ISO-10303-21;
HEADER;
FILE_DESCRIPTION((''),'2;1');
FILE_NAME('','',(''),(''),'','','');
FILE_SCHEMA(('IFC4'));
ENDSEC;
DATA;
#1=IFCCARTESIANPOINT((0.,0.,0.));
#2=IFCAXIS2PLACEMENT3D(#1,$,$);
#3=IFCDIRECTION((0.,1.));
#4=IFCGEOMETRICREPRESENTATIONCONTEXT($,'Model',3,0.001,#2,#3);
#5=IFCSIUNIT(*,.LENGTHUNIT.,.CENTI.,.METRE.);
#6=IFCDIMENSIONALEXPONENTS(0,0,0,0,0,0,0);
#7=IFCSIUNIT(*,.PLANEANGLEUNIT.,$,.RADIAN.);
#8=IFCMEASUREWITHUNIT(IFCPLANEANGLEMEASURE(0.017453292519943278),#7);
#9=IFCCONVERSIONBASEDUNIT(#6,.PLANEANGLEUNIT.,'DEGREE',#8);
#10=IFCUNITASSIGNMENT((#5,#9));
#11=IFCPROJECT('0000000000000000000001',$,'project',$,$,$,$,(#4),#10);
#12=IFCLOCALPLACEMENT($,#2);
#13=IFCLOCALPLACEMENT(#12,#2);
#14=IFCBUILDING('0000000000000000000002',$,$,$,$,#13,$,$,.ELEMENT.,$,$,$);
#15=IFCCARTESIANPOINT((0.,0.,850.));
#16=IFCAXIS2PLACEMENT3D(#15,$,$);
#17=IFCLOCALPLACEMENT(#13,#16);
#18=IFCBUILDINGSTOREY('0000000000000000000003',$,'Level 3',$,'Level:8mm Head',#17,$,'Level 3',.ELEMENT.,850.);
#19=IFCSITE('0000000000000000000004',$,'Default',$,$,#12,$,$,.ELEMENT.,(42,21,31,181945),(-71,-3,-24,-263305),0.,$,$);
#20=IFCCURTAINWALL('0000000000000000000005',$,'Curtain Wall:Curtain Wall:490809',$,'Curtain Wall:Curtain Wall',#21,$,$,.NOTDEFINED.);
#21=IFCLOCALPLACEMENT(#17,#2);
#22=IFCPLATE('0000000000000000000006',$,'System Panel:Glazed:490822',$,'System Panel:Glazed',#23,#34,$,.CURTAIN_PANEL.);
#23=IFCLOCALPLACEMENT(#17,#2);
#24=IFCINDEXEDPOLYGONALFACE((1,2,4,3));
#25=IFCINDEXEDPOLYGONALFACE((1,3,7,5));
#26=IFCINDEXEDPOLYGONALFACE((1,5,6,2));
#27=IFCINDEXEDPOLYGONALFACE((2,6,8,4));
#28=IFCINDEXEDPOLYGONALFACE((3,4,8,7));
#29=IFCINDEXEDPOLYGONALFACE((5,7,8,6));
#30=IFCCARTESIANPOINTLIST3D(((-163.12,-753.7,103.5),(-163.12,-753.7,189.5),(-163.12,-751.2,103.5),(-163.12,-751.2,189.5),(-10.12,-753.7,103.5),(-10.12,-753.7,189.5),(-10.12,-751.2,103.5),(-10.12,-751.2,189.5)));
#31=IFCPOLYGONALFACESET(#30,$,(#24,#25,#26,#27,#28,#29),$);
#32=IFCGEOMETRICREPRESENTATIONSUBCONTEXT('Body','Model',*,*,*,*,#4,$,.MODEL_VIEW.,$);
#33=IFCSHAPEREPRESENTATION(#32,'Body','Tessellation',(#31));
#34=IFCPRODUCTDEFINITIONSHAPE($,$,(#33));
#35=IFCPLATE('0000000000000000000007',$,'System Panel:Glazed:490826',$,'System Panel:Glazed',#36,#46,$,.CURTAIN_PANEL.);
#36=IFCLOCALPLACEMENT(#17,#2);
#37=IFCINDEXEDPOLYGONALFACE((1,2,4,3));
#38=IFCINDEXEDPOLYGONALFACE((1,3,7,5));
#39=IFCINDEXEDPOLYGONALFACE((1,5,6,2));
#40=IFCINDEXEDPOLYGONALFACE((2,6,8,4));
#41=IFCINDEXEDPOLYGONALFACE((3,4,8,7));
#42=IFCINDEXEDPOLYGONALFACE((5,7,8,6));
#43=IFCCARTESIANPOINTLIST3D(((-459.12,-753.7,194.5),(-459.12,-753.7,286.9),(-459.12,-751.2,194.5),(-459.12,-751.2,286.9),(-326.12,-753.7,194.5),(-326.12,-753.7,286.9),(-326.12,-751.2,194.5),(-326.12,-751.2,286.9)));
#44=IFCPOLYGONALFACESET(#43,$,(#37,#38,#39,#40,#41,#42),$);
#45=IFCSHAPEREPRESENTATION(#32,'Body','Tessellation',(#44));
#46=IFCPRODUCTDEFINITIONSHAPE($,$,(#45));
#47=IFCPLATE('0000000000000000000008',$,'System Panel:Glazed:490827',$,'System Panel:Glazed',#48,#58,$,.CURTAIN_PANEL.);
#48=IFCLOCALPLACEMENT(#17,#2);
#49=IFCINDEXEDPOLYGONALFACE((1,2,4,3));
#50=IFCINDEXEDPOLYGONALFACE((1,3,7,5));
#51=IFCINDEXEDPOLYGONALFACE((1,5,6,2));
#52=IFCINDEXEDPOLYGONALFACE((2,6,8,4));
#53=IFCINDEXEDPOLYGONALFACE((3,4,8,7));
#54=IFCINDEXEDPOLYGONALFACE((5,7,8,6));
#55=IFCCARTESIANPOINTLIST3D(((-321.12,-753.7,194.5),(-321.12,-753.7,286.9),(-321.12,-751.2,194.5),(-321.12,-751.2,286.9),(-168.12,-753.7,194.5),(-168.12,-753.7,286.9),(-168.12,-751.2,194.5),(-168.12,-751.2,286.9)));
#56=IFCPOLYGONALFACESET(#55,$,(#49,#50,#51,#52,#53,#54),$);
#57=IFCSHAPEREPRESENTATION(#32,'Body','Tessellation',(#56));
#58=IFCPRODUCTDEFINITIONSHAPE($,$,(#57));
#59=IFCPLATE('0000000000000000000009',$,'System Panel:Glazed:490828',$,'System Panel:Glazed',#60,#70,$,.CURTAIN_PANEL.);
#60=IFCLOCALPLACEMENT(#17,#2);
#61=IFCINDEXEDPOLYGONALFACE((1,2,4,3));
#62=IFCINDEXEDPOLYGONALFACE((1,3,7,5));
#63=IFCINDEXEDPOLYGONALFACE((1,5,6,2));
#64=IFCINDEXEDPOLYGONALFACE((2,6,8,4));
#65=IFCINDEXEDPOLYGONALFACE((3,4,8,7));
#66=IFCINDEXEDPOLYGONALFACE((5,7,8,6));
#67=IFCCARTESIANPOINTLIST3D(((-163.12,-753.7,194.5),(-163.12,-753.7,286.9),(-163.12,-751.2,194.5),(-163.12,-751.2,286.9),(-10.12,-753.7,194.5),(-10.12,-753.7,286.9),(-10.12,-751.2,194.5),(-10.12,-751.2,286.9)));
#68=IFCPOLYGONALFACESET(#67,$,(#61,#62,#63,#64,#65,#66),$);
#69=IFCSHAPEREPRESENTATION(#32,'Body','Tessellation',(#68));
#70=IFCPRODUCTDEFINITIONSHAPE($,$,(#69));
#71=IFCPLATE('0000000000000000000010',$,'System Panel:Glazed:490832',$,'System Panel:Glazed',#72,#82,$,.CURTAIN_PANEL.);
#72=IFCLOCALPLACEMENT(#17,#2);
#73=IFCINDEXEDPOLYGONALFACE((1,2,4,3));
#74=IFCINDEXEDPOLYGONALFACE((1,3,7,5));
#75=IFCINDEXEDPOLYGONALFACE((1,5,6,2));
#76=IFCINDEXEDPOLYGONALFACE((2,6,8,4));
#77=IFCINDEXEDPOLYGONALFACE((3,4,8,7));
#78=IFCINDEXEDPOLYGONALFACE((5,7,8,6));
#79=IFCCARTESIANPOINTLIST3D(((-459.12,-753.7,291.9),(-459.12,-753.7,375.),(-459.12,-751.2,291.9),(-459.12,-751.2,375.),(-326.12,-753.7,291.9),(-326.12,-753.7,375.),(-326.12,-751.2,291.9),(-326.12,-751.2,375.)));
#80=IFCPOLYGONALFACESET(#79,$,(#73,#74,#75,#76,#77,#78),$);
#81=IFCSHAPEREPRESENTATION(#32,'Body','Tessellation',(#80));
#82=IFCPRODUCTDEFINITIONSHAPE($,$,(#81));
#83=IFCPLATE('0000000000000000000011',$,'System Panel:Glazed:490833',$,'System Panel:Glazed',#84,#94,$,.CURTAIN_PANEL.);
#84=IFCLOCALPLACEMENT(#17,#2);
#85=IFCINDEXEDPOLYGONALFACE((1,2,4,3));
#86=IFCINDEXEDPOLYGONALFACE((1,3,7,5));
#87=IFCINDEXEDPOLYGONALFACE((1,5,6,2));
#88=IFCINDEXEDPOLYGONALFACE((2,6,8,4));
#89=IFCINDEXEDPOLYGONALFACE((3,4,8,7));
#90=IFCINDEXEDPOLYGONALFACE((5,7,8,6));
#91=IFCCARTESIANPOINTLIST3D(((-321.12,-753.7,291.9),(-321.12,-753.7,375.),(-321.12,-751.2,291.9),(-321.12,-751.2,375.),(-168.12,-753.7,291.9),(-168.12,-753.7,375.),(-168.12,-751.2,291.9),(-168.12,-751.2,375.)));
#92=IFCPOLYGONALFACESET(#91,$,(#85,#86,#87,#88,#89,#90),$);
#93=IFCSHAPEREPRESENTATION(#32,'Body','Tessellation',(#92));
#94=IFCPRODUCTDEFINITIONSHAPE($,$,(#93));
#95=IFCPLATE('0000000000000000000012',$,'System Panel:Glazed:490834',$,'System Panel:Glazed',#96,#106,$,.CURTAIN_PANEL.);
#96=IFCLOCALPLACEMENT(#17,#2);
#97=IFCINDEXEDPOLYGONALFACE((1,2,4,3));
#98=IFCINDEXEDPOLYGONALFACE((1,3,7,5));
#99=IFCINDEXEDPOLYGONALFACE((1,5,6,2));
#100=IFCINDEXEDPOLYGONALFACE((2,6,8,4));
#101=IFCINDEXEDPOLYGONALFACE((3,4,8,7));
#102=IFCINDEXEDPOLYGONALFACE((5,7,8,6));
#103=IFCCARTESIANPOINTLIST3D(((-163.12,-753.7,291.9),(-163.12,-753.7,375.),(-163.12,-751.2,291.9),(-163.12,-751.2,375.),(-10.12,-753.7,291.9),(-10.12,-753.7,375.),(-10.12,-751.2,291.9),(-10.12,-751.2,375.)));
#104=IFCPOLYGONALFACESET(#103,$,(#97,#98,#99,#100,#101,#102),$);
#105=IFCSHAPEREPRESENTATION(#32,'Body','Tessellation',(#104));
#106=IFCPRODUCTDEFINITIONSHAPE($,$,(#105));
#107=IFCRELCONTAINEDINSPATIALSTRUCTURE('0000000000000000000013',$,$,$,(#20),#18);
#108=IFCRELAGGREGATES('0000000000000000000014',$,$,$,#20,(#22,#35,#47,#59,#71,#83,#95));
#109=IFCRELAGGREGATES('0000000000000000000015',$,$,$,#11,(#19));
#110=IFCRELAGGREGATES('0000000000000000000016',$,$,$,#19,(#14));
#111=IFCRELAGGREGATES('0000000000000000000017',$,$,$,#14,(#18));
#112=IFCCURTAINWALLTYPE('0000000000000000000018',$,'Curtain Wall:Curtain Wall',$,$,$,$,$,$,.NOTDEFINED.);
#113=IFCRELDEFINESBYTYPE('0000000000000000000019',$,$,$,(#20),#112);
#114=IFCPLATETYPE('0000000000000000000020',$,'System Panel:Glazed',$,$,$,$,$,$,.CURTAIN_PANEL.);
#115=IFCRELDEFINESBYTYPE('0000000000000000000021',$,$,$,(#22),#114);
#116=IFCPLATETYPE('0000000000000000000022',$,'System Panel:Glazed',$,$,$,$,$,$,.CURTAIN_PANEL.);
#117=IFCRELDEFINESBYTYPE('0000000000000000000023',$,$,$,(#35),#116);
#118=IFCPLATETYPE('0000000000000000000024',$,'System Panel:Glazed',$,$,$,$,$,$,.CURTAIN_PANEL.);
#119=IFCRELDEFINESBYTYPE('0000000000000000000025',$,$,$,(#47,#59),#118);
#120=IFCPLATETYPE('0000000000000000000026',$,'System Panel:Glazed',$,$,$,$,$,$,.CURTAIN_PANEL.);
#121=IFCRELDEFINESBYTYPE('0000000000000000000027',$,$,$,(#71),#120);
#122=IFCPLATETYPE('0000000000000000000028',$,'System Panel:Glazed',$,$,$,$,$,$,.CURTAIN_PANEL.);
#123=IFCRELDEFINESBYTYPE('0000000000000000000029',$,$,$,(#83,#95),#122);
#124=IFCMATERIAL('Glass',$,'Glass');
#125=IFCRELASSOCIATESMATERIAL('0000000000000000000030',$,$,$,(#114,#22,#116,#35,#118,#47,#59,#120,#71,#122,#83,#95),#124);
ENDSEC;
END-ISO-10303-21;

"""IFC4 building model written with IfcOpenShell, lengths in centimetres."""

from ifc_helpers import new_model, entity, si_unit, converted_unit, direction, frame, origin, place, context, subcontext, project, spatial, indexed_curve, outline, extrude, source, transform, mapped, material, type_object, type_shapes, element, aggregate, save


model = new_model("IFC4")

# Units and contexts
model_context = context("Model", 3, precision=0.001, world=origin(), true_north=direction((0.0, 1.0)))
body_context = subcontext(model_context, "Body", "Model", "MODEL_VIEW")
ifc_project = project(units=[si_unit("LENGTHUNIT", "METRE", prefix="CENTI"), converted_unit("PLANEANGLEUNIT", "DEGREE", entity("IfcPlaneAngleMeasure", 0.017453292519943278), si_unit("PLANEANGLEUNIT", "RADIAN"), dimensions=[0, 0, 0, 0, 0, 0, 0])], contexts=[model_context])

# Site, building, storey
site_placement = place(None, origin())
site = spatial("IfcSite", under=ifc_project, at=site_placement, Name="Default", CompositionType="ELEMENT", RefLatitude=(42, 21, 31, 181945), RefLongitude=(-71, -3, -24, -263305), RefElevation=0.0)
building_placement = place(site_placement, origin())
building = spatial("IfcBuilding", under=site, at=building_placement, CompositionType="ELEMENT")
storey_placement = place(building_placement, frame((0.0, 0.0, 850.0)))
storey = spatial("IfcBuildingStorey", under=building, at=storey_placement, Name="Level 3", ObjectType="Level:8mm Head", LongName="Level 3", CompositionType="ELEMENT", Elevation=850.0)

# Curtain wall, plates
curtain_wall_type = type_object("IfcCurtainWallType", Name="Curtain Wall:Curtain Wall", PredefinedType="NOTDEFINED")
curtain_wall_placement = place(storey_placement, frame((0.0, 0.0, -850.0)))
curtain_wall = element("IfcCurtainWall", 1, at=curtain_wall_placement, inside=storey, type_object=curtain_wall_type, Name="Curtain Wall:Curtain Wall:490809", ObjectType="Curtain Wall:Curtain Wall", PredefinedType="NOTDEFINED")
ifc_material_1 = material(Name="Glass", Category="Glass")
plate_type_1 = type_object("IfcPlateType", Name="System Panel:Glazed", PredefinedType="CURTAIN_PANEL", material=ifc_material_1)
shared_shape_1 = source(origin(), body_context, "Body", "SweptSolid", [
    extrude(outline(indexed_curve([(-1.25, -76.5), (1.25, -76.5), (1.25, 76.5), (-1.25, 76.5), (-1.25, -76.5)], self_intersect=False)), frame((0.0, 3.7, 0.0), z_axis=(0.0, 0.0, 1.0), x_axis=(0.0, 1.0, 0.0)), (0.0, 0.0, 1.0), 86.0),
])
type_shapes(plate_type_1, [shared_shape_1])
plate_1_placement = place(curtain_wall_placement, frame((-86.62, -756.15, 953.5)))
plate_1 = element("IfcPlate", 2, at=plate_1_placement, type_object=plate_type_1, material=ifc_material_1, Name="System Panel:Glazed:490822", ObjectType="System Panel:Glazed", PredefinedType="CURTAIN_PANEL", context=body_context, shape_type="MappedRepresentation", body=[
    mapped(shared_shape_1, transform((0.0, 0.0, 0.0), scale=1.0)),
])
plate_type_2 = type_object("IfcPlateType", Name="System Panel:Glazed", PredefinedType="CURTAIN_PANEL", material=ifc_material_1)
shared_shape_2 = source(origin(), body_context, "Body", "SweptSolid", [
    extrude(outline(indexed_curve([(-1.25, -66.5), (1.25, -66.5), (1.25, 66.5), (-1.25, 66.5), (-1.25, -66.5)], self_intersect=False)), frame((0.0, 3.7, 0.0), z_axis=(0.0, 0.0, 1.0), x_axis=(0.0, 1.0, 0.0)), (0.0, 0.0, 1.0), 92.4),
])
type_shapes(plate_type_2, [shared_shape_2])
plate_2_placement = place(curtain_wall_placement, frame((-392.62, -756.15, 1044.5)))
plate_2 = element("IfcPlate", 3, at=plate_2_placement, type_object=plate_type_2, material=ifc_material_1, Name="System Panel:Glazed:490826", ObjectType="System Panel:Glazed", PredefinedType="CURTAIN_PANEL", context=body_context, shape_type="MappedRepresentation", body=[
    mapped(shared_shape_2, transform((0.0, 0.0, 0.0), scale=1.0)),
])
plate_type_3 = type_object("IfcPlateType", Name="System Panel:Glazed", PredefinedType="CURTAIN_PANEL", material=ifc_material_1)
shared_shape_3 = source(origin(), body_context, "Body", "SweptSolid", [
    extrude(outline(indexed_curve([(-1.25, -76.5), (1.25, -76.5), (1.25, 76.5), (-1.25, 76.5), (-1.25, -76.5)], self_intersect=False)), frame((0.0, 3.7, 0.0), z_axis=(0.0, 0.0, 1.0), x_axis=(0.0, 1.0, 0.0)), (0.0, 0.0, 1.0), 92.4),
])
type_shapes(plate_type_3, [shared_shape_3])
plate_3_placement = place(curtain_wall_placement, frame((-244.62, -756.15, 1044.5)))
plate_3 = element("IfcPlate", 4, at=plate_3_placement, type_object=plate_type_3, material=ifc_material_1, Name="System Panel:Glazed:490827", ObjectType="System Panel:Glazed", PredefinedType="CURTAIN_PANEL", context=body_context, shape_type="MappedRepresentation", body=[
    mapped(shared_shape_3, transform((0.0, 0.0, 0.0), scale=1.0)),
])
plate_4_placement = place(curtain_wall_placement, frame((-86.62, -756.15, 1044.5)))
plate_4 = element("IfcPlate", 5, at=plate_4_placement, type_object=plate_type_3, material=ifc_material_1, Name="System Panel:Glazed:490828", ObjectType="System Panel:Glazed", PredefinedType="CURTAIN_PANEL", context=body_context, shape_type="MappedRepresentation", body=[
    mapped(shared_shape_3, transform((0.0, 0.0, 0.0), scale=1.0)),
])
plate_type_4 = type_object("IfcPlateType", Name="System Panel:Glazed", PredefinedType="CURTAIN_PANEL", material=ifc_material_1)
shared_shape_4 = source(origin(), body_context, "Body", "SweptSolid", [
    extrude(outline(indexed_curve([(-1.25, -66.5), (1.25, -66.5), (1.25, 66.5), (-1.25, 66.5), (-1.25, -66.5)], self_intersect=False)), frame((0.0, 3.7, 0.0), z_axis=(0.0, 0.0, 1.0), x_axis=(0.0, 1.0, 0.0)), (0.0, 0.0, 1.0), 83.1),
])
type_shapes(plate_type_4, [shared_shape_4])
plate_5_placement = place(curtain_wall_placement, frame((-392.62, -756.15, 1141.9)))
plate_5 = element("IfcPlate", 6, at=plate_5_placement, type_object=plate_type_4, material=ifc_material_1, Name="System Panel:Glazed:490832", ObjectType="System Panel:Glazed", PredefinedType="CURTAIN_PANEL", context=body_context, shape_type="MappedRepresentation", body=[
    mapped(shared_shape_4, transform((0.0, 0.0, 0.0), scale=1.0)),
])
plate_type_5 = type_object("IfcPlateType", Name="System Panel:Glazed", PredefinedType="CURTAIN_PANEL", material=ifc_material_1)
shared_shape_5 = source(origin(), body_context, "Body", "SweptSolid", [
    extrude(outline(indexed_curve([(-1.25, -76.5), (1.25, -76.5), (1.25, 76.5), (-1.25, 76.5), (-1.25, -76.5)], self_intersect=False)), frame((0.0, 3.7, 0.0), z_axis=(0.0, 0.0, 1.0), x_axis=(0.0, 1.0, 0.0)), (0.0, 0.0, 1.0), 83.1),
])
type_shapes(plate_type_5, [shared_shape_5])
plate_6_placement = place(curtain_wall_placement, frame((-244.62, -756.15, 1141.9)))
plate_6 = element("IfcPlate", 7, at=plate_6_placement, type_object=plate_type_5, material=ifc_material_1, Name="System Panel:Glazed:490833", ObjectType="System Panel:Glazed", PredefinedType="CURTAIN_PANEL", context=body_context, shape_type="MappedRepresentation", body=[
    mapped(shared_shape_5, transform((0.0, 0.0, 0.0), scale=1.0)),
])
plate_7_placement = place(curtain_wall_placement, frame((-86.62, -756.15, 1141.9)))
plate_7 = element("IfcPlate", 8, at=plate_7_placement, type_object=plate_type_5, material=ifc_material_1, Name="System Panel:Glazed:490834", ObjectType="System Panel:Glazed", PredefinedType="CURTAIN_PANEL", context=body_context, shape_type="MappedRepresentation", body=[
    mapped(shared_shape_5, transform((0.0, 0.0, 0.0), scale=1.0)),
])
aggregate(curtain_wall, [plate_1, plate_2, plate_3, plate_4, plate_5, plate_6, plate_7])

save(model, "model.ifc")
